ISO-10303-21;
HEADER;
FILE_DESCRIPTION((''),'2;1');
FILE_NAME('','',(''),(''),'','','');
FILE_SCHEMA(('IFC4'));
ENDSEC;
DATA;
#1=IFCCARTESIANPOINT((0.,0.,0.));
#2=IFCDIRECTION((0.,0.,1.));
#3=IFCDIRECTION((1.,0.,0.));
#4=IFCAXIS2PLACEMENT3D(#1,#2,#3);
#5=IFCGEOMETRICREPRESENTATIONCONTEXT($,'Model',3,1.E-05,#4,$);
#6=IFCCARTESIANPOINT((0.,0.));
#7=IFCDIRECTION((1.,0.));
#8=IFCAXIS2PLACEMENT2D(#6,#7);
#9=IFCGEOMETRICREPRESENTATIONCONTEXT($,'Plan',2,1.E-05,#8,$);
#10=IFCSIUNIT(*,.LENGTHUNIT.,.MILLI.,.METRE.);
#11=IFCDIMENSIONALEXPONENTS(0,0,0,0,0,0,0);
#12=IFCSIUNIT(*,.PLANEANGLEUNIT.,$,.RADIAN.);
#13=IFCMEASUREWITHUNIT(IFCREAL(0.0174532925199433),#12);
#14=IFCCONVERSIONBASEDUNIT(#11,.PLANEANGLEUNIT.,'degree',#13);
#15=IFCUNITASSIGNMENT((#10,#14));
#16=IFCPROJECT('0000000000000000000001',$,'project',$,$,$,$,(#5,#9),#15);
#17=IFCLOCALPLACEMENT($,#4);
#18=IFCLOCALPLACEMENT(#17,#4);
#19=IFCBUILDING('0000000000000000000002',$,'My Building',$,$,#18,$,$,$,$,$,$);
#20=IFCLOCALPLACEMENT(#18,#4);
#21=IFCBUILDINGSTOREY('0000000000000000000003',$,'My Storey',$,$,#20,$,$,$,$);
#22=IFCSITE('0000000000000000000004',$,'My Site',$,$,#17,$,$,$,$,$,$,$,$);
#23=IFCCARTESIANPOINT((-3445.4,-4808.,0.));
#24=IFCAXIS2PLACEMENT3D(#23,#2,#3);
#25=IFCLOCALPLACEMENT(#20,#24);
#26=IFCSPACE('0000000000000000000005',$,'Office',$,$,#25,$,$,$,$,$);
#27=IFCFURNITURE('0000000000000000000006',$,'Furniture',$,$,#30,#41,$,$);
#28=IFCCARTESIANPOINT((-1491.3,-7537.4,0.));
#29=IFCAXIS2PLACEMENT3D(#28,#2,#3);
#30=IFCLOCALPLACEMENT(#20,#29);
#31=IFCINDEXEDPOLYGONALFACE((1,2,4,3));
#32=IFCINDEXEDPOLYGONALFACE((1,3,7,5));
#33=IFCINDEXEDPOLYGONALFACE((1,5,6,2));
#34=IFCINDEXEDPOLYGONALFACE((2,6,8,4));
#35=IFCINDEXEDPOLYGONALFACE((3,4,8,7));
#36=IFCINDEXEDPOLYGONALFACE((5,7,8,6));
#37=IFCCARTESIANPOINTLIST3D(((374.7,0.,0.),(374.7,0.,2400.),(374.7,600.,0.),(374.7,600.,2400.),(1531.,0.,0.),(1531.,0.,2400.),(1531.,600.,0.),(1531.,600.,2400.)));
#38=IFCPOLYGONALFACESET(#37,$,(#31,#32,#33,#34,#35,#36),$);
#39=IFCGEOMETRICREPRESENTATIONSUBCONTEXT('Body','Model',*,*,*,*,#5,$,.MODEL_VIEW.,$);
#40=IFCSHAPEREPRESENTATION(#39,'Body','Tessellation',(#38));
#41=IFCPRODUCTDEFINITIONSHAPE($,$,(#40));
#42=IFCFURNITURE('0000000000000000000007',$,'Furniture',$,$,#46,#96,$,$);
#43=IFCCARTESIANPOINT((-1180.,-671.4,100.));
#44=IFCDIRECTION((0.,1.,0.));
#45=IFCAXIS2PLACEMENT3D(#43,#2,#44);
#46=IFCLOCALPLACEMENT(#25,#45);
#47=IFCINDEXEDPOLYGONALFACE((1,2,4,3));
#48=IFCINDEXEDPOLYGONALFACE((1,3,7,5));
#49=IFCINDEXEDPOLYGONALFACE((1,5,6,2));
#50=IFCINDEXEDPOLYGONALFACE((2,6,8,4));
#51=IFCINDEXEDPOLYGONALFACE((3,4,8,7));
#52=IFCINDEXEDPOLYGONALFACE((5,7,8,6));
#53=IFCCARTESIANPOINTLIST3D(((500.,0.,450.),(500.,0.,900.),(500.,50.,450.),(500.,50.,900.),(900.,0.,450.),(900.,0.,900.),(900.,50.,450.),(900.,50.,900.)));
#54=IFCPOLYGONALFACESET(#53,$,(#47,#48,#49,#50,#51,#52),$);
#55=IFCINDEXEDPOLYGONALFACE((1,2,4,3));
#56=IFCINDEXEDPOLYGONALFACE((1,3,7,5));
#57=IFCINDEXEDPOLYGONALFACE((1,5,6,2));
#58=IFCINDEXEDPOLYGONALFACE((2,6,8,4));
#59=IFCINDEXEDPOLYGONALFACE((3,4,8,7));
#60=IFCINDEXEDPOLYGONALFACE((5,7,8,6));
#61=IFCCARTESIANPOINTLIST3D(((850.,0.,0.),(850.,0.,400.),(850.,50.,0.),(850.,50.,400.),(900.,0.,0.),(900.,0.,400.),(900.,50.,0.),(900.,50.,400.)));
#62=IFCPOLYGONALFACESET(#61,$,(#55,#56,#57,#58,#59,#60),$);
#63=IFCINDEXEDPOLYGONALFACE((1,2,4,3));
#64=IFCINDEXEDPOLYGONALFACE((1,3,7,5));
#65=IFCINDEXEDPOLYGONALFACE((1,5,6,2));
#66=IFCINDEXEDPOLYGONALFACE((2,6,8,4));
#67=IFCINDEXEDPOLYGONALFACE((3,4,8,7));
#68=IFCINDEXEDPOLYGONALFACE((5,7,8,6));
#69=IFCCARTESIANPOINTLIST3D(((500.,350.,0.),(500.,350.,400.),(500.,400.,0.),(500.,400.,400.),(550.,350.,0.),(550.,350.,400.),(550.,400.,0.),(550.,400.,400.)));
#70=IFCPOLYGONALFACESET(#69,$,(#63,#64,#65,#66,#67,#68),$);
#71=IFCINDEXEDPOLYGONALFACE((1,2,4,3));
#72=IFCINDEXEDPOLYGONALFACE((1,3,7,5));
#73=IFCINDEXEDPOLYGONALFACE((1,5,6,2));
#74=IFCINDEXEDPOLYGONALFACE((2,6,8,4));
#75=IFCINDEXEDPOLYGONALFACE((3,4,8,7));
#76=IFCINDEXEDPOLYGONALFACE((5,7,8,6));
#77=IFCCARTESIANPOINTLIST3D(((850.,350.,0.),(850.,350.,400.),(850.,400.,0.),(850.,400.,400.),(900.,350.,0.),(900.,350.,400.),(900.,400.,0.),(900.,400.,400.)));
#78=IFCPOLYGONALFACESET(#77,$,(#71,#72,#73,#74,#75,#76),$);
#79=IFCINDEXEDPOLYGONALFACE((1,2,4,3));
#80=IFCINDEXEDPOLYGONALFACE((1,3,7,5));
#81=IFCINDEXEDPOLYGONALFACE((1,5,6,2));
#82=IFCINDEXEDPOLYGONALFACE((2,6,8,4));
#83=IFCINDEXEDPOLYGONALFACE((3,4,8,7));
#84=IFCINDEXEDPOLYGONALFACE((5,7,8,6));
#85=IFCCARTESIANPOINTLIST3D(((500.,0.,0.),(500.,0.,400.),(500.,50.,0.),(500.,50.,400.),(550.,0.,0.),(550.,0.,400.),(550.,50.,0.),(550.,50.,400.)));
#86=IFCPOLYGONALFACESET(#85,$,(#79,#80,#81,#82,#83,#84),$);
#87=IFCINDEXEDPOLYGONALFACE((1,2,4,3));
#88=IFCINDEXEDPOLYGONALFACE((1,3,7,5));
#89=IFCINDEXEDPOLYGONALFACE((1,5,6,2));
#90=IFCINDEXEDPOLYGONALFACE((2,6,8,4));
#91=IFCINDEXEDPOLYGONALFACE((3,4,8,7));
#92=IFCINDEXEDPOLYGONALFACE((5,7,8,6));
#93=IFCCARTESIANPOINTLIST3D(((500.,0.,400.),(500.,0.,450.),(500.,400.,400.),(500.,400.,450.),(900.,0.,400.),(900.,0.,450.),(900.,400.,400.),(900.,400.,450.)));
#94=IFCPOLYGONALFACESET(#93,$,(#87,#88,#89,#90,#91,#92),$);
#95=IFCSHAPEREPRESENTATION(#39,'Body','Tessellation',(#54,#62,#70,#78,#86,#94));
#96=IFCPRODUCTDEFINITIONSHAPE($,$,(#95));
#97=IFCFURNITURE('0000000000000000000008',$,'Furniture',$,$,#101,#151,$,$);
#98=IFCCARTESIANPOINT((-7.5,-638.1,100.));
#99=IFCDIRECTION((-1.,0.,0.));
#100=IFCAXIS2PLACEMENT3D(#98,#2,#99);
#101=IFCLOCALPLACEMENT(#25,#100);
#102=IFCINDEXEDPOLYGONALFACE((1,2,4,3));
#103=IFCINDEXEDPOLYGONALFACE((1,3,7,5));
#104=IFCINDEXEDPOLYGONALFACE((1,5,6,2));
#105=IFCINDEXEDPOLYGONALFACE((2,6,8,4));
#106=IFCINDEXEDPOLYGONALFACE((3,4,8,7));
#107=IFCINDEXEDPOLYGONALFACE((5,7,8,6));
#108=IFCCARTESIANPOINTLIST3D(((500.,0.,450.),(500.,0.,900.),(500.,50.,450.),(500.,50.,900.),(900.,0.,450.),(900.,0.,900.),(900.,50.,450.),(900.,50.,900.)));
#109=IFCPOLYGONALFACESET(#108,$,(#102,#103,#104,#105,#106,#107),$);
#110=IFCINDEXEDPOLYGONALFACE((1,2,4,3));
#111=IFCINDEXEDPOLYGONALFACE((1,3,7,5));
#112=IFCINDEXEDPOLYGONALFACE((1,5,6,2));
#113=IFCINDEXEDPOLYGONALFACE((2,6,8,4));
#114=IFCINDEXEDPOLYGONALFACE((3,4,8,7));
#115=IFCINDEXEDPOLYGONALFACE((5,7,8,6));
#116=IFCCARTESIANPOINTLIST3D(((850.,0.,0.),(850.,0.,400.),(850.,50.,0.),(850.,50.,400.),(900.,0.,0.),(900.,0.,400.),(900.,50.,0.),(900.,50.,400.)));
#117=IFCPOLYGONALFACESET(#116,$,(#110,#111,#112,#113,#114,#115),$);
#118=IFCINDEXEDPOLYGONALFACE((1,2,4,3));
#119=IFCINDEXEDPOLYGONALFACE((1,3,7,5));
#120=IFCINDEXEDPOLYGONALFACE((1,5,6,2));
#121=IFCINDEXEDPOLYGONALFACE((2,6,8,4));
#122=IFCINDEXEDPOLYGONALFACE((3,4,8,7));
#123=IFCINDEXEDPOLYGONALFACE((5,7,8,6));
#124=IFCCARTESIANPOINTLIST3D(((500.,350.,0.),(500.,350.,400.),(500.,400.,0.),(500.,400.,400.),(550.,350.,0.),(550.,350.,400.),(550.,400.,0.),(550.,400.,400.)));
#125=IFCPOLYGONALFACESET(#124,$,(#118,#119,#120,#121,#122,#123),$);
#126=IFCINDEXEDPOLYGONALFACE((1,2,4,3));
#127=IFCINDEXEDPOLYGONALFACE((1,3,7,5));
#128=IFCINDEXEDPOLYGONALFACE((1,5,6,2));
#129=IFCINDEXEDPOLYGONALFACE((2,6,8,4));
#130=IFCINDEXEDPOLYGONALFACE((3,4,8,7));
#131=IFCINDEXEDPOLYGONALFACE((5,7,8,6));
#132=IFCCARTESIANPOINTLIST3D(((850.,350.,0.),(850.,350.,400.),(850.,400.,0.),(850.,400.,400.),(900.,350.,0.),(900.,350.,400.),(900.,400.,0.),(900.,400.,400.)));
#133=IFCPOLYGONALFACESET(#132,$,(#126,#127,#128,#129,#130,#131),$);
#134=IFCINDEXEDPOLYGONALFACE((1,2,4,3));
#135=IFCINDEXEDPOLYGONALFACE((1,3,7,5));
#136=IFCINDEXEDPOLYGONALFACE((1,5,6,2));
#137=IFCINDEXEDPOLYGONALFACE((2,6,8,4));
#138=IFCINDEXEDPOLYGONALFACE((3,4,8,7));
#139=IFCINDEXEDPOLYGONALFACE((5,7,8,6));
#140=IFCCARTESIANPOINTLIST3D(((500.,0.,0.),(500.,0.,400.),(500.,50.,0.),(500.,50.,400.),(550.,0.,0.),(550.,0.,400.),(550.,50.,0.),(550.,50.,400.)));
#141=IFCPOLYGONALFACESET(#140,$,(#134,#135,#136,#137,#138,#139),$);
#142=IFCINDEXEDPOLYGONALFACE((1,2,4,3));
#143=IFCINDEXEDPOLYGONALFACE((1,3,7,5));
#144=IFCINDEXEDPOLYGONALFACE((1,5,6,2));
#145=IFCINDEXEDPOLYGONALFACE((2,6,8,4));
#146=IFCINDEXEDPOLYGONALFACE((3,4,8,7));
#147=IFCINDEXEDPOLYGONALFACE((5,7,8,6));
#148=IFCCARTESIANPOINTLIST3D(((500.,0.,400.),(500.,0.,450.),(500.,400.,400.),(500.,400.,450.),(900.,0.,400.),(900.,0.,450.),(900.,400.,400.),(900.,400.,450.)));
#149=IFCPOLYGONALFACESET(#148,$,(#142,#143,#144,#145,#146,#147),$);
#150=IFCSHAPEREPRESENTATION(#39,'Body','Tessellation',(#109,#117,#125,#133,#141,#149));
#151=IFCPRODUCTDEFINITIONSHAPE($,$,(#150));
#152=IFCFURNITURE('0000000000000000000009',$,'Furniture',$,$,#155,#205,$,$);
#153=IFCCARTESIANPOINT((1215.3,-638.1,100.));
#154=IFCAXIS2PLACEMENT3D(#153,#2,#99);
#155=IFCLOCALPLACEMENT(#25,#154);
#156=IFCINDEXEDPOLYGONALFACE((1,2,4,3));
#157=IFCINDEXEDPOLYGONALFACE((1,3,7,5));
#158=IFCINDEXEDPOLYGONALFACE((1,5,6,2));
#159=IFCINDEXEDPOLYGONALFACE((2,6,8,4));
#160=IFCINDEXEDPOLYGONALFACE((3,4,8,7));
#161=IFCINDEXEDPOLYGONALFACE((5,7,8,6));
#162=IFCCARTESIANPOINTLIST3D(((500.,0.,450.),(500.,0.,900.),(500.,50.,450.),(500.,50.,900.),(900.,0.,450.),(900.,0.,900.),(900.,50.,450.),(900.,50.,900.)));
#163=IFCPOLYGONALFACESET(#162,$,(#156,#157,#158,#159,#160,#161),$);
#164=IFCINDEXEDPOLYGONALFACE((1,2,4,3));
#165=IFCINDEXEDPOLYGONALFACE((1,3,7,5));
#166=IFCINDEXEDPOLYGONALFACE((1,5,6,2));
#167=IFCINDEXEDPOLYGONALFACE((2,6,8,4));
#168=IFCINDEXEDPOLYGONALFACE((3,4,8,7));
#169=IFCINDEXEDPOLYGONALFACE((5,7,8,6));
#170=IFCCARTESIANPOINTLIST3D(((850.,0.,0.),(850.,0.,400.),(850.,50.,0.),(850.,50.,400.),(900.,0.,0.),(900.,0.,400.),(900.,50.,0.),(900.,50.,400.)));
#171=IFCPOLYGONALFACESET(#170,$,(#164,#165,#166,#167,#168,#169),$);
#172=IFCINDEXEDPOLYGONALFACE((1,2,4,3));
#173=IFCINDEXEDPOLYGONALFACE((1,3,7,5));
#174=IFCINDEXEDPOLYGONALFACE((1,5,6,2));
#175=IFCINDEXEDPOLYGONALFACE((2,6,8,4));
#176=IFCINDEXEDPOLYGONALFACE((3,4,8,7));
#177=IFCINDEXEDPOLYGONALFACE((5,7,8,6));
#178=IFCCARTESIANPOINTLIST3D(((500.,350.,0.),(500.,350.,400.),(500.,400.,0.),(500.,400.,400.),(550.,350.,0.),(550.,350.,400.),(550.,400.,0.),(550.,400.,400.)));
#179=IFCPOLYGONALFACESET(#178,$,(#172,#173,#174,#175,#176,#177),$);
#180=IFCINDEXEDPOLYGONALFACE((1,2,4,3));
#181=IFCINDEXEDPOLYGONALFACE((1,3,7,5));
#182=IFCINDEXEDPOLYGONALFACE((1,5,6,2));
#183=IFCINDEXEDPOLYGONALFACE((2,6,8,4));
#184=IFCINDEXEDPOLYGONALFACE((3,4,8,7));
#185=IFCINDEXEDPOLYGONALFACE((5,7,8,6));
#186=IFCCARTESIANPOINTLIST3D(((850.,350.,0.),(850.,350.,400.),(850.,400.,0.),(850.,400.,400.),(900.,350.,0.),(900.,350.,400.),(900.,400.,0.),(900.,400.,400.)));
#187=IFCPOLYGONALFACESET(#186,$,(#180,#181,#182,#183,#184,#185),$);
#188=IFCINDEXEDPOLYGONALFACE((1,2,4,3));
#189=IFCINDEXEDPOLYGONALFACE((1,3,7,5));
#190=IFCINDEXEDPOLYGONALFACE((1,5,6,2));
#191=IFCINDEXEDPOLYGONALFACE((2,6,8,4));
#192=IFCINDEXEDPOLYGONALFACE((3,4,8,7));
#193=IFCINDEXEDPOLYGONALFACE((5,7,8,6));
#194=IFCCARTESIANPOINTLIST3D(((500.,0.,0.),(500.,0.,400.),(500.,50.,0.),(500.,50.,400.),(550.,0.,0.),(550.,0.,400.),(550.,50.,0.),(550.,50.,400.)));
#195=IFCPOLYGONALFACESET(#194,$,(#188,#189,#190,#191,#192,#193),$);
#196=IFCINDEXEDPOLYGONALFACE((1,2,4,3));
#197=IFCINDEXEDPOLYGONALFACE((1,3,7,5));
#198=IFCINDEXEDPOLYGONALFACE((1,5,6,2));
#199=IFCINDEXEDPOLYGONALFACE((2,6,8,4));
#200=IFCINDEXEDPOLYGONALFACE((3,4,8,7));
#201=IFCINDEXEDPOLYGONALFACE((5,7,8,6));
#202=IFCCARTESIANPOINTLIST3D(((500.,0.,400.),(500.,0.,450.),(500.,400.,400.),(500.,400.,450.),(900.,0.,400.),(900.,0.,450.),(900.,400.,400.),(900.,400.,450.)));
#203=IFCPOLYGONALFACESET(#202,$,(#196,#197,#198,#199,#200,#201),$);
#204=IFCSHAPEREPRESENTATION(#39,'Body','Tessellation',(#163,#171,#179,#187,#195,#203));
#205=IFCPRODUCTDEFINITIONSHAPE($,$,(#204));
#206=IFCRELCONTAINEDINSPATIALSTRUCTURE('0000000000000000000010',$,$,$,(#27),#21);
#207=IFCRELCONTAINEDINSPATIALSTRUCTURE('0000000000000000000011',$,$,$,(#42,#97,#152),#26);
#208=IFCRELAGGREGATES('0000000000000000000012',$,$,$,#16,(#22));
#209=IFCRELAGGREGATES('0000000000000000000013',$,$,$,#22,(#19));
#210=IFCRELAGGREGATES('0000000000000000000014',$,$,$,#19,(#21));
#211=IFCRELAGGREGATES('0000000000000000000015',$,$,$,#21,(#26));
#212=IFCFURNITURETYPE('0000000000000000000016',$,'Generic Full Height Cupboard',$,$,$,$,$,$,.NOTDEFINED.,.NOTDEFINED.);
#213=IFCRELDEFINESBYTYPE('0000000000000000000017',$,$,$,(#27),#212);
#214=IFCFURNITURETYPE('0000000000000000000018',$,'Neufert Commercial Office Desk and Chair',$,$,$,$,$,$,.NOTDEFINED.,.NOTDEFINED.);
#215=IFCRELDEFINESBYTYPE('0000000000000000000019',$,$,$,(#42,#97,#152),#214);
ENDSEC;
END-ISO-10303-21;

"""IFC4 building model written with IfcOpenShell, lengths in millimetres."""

from ifc_helpers import new_model, entity, si_unit, converted_unit, frame, origin_with_axes, origin_2d_with_axis, place, context, subcontext, project, spatial, line, indexed_curve, outline, extrude, shape, source, transform, mapped, type_object, type_shapes, element, save


model = new_model("IFC4")

# Units and contexts
model_context = context("Model", 3, precision=1e-05, world=origin_with_axes())
plan_context = context("Plan", 2, precision=1e-05, world=origin_2d_with_axis())
body_context_1 = subcontext(model_context, "Body", "Model", "MODEL_VIEW")
body_context_2 = subcontext(plan_context, "Body", "Plan", "PLAN_VIEW")
ifc_project = project(units=[si_unit("LENGTHUNIT", "METRE", prefix="MILLI"), converted_unit("PLANEANGLEUNIT", "degree", entity("IfcReal", 0.0174532925199433), si_unit("PLANEANGLEUNIT", "RADIAN"), dimensions=[0, 0, 0, 0, 0, 0, 0])], contexts=[model_context, plan_context])

# Site, building, storey
site_placement = place(None, origin_with_axes())
site = spatial("IfcSite", under=ifc_project, at=site_placement, Name="My Site")
building_placement = place(site_placement, origin_with_axes())
building = spatial("IfcBuilding", under=site, at=building_placement, Name="My Building")
storey_placement = place(building_placement, origin_with_axes())
storey = spatial("IfcBuildingStorey", under=building, at=storey_placement, Name="My Storey")

# Shared definitions
space_1_placement = place(storey_placement, frame((-3445.4, -4808.0, 0.0), z_axis=(0.0, 0.0, 1.0), x_axis=(1.0, 0.0, 0.0)))
space_1 = spatial("IfcSpace", under=storey, at=space_1_placement, Name="Office")

# Furniture
furniture_type_1 = type_object("IfcFurnitureType", Name="Generic Full Height Cupboard", AssemblyPlace="NOTDEFINED", PredefinedType="NOTDEFINED")
shared_shape_1 = source(origin_with_axes(), body_context_1, "Body", "SolidModel", [
    extrude(outline(indexed_curve([(374.7, 0.0), (1531.0, 0.0), (1531.0, 600.0), (374.7, 600.0), (374.7, 0.0)])), origin_with_axes(), (0.0, 0.0, 1.0), 2400.0),
])
shared_shape_2 = source(origin_with_axes(), body_context_2, "Body", "Curve2D", [
    entity("IfcIndexedPolyCurve", entity("IfcCartesianPointList2D", [[0.0, 0.0], [600.0, 0.0], [600.0, 600.0], [0.0, 600.0]]), [entity("IfcLineIndex", [1, 2, 3, 4, 1])]),
])
type_shapes(furniture_type_1, [shared_shape_1, shared_shape_2])
furniture_placement = place(storey_placement, frame((-1491.3, -7537.4, 0.0), z_axis=(0.0, 0.0, 1.0), x_axis=(1.0, 0.0, 0.0)))
element("IfcFurniture", 1, at=furniture_placement, inside=storey, type_object=furniture_type_1, Name="Furniture", shapes=[
    shape(body_context_1, "Body", "MappedRepresentation", [mapped(shared_shape_1, transform((0.0, 0.0, 0.0), x_axis=(1.0, 0.0, 0.0), y_axis=(0.0, 1.0, 0.0), z_axis=(0.0, 0.0, 1.0), scale=1.0))]),
    shape(body_context_2, "Body", "MappedRepresentation", [mapped(shared_shape_2, transform((0.0, 0.0, 0.0), x_axis=(1.0, 0.0, 0.0), y_axis=(0.0, 1.0, 0.0), z_axis=(0.0, 0.0, 1.0), scale=1.0))]),
])
furniture_type_2 = type_object("IfcFurnitureType", Name="Neufert Commercial Office Desk and Chair", AssemblyPlace="NOTDEFINED", PredefinedType="NOTDEFINED")
shared_shape_3 = source(origin_with_axes(), body_context_1, "Body", "SolidModel", [
    extrude(outline(indexed_curve([(-200.0, 50.0), (-200.0, 0.0), (200.0, 0.0), (200.0, 50.0), (-200.0, 50.0)])), frame((700.0, 0.0, 900.0), z_axis=(0.0, 0.0, 1.0), x_axis=(1.0, 0.0, 0.0)), (0.0, 0.0, -1.0), 450.0),
    extrude(outline(indexed_curve([(200.0, 0.0), (150.0, 0.0), (150.0, 50.0), (200.0, 50.0)], segments=[line(1, 2, 3, 4, 1)])), frame((700.0, 0.0, 0.0), z_axis=(0.0, 0.0, 1.0), x_axis=(1.0, 0.0, 0.0)), (0.0, 0.0, 1.0), 400.0),
    extrude(outline(indexed_curve([(-200.0, 350.0), (-150.0, 350.0), (-150.0, 400.0), (-200.0, 400.0), (-200.0, 350.0)])), frame((700.0, 0.0, 0.0), z_axis=(0.0, 0.0, 1.0), x_axis=(1.0, 0.0, 0.0)), (0.0, 0.0, 1.0), 400.0),
    extrude(outline(indexed_curve([(200.0, 400.0), (150.0, 400.0), (150.0, 350.0), (200.0, 350.0)], segments=[line(1, 2, 3, 4, 1)])), frame((700.0, 0.0, 0.0), z_axis=(0.0, 0.0, 1.0), x_axis=(1.0, 0.0, 0.0)), (0.0, 0.0, 1.0), 400.0),
    extrude(outline(indexed_curve([(-200.0, 0.0), (-150.0, 0.0), (-150.0, 50.0), (-200.0, 50.0)], segments=[line(1, 2, 3, 4, 1)])), frame((700.0, 0.0, 0.0), z_axis=(0.0, 0.0, 1.0), x_axis=(1.0, 0.0, 0.0)), (0.0, 0.0, 1.0), 400.0),
    extrude(outline(indexed_curve([(-200.0, 400.0), (200.0, 400.0), (200.0, 0.0), (-200.0, 0.0), (-200.0, 400.0)])), frame((700.0, 0.0, 450.0), z_axis=(0.0, 0.0, 1.0), x_axis=(1.0, 0.0, 0.0)), (0.0, 0.0, -1.0), 50.0),
])
shared_shape_4 = source(origin_with_axes(), body_context_2, "Body", "Curve2D", [
    entity("IfcIndexedPolyCurve", entity("IfcCartesianPointList2D", [[0.0, 450.0], [1400.0, 450.0], [1400.0, 1150.0], [0.0, 1150.0]]), [entity("IfcLineIndex", [1, 2, 3, 4, 1])]),
    entity("IfcIndexedPolyCurve", entity("IfcCartesianPointList2D", [[500.0, 400.0], [900.0, 400.0]])),
    entity("IfcIndexedPolyCurve", entity("IfcCartesianPointList2D", [[500.0, 400.0], [500.0, 200.0], [558.6, 58.6], [700.0, 0.0], [841.4, 58.6], [900.0, 200.0], [900.0, 400.0]]), [entity("IfcLineIndex", [1, 2]), entity("IfcArcIndex", [2, 3, 4]), entity("IfcArcIndex", [4, 5, 6]), entity("IfcLineIndex", [6, 7])]),
    entity("IfcIndexedPolyCurve", entity("IfcCartesianPointList2D", [[540.0, 400.0], [540.0, 200.0], [586.9, 86.9], [700.0, 40.0], [813.1, 86.9], [860.0, 200.0], [860.0, 400.0]]), [entity("IfcLineIndex", [1, 2]), entity("IfcArcIndex", [2, 3, 4]), entity("IfcArcIndex", [4, 5, 6]), entity("IfcLineIndex", [6, 7])]),
])
type_shapes(furniture_type_2, [shared_shape_3, shared_shape_4])
for number, where, z_axis, x_axis, name in (
    (2, (-1180.0, -671.4, 100.0), (0.0, 0.0, 1.0), (0.0, 1.0, 0.0), "Furniture"),
    (3, (-7.5, -638.1, 100.0), (0.0, 0.0, 1.0), (-1.0, 0.0, 0.0), "Furniture"),
    (4, (1215.3, -638.1, 100.0), (0.0, 0.0, 1.0), (-1.0, 0.0, 0.0), "Furniture"),
):
    element("IfcFurniture", number, at=place(space_1_placement, frame(where, z_axis=z_axis, x_axis=x_axis)), inside=space_1, type_object=furniture_type_2, Name=name, shapes=[
        shape(body_context_1, "Body", "MappedRepresentation", [mapped(shared_shape_3, transform((0.0, 0.0, 0.0), x_axis=(1.0, 0.0, 0.0), y_axis=(0.0, 1.0, 0.0), z_axis=(0.0, 0.0, 1.0), scale=1.0))]),
        shape(body_context_2, "Body", "MappedRepresentation", [mapped(shared_shape_4, transform((0.0, 0.0, 0.0), x_axis=(1.0, 0.0, 0.0), y_axis=(0.0, 1.0, 0.0), z_axis=(0.0, 0.0, 1.0), scale=1.0))]),
    ])

save(model, "model.ifc")
